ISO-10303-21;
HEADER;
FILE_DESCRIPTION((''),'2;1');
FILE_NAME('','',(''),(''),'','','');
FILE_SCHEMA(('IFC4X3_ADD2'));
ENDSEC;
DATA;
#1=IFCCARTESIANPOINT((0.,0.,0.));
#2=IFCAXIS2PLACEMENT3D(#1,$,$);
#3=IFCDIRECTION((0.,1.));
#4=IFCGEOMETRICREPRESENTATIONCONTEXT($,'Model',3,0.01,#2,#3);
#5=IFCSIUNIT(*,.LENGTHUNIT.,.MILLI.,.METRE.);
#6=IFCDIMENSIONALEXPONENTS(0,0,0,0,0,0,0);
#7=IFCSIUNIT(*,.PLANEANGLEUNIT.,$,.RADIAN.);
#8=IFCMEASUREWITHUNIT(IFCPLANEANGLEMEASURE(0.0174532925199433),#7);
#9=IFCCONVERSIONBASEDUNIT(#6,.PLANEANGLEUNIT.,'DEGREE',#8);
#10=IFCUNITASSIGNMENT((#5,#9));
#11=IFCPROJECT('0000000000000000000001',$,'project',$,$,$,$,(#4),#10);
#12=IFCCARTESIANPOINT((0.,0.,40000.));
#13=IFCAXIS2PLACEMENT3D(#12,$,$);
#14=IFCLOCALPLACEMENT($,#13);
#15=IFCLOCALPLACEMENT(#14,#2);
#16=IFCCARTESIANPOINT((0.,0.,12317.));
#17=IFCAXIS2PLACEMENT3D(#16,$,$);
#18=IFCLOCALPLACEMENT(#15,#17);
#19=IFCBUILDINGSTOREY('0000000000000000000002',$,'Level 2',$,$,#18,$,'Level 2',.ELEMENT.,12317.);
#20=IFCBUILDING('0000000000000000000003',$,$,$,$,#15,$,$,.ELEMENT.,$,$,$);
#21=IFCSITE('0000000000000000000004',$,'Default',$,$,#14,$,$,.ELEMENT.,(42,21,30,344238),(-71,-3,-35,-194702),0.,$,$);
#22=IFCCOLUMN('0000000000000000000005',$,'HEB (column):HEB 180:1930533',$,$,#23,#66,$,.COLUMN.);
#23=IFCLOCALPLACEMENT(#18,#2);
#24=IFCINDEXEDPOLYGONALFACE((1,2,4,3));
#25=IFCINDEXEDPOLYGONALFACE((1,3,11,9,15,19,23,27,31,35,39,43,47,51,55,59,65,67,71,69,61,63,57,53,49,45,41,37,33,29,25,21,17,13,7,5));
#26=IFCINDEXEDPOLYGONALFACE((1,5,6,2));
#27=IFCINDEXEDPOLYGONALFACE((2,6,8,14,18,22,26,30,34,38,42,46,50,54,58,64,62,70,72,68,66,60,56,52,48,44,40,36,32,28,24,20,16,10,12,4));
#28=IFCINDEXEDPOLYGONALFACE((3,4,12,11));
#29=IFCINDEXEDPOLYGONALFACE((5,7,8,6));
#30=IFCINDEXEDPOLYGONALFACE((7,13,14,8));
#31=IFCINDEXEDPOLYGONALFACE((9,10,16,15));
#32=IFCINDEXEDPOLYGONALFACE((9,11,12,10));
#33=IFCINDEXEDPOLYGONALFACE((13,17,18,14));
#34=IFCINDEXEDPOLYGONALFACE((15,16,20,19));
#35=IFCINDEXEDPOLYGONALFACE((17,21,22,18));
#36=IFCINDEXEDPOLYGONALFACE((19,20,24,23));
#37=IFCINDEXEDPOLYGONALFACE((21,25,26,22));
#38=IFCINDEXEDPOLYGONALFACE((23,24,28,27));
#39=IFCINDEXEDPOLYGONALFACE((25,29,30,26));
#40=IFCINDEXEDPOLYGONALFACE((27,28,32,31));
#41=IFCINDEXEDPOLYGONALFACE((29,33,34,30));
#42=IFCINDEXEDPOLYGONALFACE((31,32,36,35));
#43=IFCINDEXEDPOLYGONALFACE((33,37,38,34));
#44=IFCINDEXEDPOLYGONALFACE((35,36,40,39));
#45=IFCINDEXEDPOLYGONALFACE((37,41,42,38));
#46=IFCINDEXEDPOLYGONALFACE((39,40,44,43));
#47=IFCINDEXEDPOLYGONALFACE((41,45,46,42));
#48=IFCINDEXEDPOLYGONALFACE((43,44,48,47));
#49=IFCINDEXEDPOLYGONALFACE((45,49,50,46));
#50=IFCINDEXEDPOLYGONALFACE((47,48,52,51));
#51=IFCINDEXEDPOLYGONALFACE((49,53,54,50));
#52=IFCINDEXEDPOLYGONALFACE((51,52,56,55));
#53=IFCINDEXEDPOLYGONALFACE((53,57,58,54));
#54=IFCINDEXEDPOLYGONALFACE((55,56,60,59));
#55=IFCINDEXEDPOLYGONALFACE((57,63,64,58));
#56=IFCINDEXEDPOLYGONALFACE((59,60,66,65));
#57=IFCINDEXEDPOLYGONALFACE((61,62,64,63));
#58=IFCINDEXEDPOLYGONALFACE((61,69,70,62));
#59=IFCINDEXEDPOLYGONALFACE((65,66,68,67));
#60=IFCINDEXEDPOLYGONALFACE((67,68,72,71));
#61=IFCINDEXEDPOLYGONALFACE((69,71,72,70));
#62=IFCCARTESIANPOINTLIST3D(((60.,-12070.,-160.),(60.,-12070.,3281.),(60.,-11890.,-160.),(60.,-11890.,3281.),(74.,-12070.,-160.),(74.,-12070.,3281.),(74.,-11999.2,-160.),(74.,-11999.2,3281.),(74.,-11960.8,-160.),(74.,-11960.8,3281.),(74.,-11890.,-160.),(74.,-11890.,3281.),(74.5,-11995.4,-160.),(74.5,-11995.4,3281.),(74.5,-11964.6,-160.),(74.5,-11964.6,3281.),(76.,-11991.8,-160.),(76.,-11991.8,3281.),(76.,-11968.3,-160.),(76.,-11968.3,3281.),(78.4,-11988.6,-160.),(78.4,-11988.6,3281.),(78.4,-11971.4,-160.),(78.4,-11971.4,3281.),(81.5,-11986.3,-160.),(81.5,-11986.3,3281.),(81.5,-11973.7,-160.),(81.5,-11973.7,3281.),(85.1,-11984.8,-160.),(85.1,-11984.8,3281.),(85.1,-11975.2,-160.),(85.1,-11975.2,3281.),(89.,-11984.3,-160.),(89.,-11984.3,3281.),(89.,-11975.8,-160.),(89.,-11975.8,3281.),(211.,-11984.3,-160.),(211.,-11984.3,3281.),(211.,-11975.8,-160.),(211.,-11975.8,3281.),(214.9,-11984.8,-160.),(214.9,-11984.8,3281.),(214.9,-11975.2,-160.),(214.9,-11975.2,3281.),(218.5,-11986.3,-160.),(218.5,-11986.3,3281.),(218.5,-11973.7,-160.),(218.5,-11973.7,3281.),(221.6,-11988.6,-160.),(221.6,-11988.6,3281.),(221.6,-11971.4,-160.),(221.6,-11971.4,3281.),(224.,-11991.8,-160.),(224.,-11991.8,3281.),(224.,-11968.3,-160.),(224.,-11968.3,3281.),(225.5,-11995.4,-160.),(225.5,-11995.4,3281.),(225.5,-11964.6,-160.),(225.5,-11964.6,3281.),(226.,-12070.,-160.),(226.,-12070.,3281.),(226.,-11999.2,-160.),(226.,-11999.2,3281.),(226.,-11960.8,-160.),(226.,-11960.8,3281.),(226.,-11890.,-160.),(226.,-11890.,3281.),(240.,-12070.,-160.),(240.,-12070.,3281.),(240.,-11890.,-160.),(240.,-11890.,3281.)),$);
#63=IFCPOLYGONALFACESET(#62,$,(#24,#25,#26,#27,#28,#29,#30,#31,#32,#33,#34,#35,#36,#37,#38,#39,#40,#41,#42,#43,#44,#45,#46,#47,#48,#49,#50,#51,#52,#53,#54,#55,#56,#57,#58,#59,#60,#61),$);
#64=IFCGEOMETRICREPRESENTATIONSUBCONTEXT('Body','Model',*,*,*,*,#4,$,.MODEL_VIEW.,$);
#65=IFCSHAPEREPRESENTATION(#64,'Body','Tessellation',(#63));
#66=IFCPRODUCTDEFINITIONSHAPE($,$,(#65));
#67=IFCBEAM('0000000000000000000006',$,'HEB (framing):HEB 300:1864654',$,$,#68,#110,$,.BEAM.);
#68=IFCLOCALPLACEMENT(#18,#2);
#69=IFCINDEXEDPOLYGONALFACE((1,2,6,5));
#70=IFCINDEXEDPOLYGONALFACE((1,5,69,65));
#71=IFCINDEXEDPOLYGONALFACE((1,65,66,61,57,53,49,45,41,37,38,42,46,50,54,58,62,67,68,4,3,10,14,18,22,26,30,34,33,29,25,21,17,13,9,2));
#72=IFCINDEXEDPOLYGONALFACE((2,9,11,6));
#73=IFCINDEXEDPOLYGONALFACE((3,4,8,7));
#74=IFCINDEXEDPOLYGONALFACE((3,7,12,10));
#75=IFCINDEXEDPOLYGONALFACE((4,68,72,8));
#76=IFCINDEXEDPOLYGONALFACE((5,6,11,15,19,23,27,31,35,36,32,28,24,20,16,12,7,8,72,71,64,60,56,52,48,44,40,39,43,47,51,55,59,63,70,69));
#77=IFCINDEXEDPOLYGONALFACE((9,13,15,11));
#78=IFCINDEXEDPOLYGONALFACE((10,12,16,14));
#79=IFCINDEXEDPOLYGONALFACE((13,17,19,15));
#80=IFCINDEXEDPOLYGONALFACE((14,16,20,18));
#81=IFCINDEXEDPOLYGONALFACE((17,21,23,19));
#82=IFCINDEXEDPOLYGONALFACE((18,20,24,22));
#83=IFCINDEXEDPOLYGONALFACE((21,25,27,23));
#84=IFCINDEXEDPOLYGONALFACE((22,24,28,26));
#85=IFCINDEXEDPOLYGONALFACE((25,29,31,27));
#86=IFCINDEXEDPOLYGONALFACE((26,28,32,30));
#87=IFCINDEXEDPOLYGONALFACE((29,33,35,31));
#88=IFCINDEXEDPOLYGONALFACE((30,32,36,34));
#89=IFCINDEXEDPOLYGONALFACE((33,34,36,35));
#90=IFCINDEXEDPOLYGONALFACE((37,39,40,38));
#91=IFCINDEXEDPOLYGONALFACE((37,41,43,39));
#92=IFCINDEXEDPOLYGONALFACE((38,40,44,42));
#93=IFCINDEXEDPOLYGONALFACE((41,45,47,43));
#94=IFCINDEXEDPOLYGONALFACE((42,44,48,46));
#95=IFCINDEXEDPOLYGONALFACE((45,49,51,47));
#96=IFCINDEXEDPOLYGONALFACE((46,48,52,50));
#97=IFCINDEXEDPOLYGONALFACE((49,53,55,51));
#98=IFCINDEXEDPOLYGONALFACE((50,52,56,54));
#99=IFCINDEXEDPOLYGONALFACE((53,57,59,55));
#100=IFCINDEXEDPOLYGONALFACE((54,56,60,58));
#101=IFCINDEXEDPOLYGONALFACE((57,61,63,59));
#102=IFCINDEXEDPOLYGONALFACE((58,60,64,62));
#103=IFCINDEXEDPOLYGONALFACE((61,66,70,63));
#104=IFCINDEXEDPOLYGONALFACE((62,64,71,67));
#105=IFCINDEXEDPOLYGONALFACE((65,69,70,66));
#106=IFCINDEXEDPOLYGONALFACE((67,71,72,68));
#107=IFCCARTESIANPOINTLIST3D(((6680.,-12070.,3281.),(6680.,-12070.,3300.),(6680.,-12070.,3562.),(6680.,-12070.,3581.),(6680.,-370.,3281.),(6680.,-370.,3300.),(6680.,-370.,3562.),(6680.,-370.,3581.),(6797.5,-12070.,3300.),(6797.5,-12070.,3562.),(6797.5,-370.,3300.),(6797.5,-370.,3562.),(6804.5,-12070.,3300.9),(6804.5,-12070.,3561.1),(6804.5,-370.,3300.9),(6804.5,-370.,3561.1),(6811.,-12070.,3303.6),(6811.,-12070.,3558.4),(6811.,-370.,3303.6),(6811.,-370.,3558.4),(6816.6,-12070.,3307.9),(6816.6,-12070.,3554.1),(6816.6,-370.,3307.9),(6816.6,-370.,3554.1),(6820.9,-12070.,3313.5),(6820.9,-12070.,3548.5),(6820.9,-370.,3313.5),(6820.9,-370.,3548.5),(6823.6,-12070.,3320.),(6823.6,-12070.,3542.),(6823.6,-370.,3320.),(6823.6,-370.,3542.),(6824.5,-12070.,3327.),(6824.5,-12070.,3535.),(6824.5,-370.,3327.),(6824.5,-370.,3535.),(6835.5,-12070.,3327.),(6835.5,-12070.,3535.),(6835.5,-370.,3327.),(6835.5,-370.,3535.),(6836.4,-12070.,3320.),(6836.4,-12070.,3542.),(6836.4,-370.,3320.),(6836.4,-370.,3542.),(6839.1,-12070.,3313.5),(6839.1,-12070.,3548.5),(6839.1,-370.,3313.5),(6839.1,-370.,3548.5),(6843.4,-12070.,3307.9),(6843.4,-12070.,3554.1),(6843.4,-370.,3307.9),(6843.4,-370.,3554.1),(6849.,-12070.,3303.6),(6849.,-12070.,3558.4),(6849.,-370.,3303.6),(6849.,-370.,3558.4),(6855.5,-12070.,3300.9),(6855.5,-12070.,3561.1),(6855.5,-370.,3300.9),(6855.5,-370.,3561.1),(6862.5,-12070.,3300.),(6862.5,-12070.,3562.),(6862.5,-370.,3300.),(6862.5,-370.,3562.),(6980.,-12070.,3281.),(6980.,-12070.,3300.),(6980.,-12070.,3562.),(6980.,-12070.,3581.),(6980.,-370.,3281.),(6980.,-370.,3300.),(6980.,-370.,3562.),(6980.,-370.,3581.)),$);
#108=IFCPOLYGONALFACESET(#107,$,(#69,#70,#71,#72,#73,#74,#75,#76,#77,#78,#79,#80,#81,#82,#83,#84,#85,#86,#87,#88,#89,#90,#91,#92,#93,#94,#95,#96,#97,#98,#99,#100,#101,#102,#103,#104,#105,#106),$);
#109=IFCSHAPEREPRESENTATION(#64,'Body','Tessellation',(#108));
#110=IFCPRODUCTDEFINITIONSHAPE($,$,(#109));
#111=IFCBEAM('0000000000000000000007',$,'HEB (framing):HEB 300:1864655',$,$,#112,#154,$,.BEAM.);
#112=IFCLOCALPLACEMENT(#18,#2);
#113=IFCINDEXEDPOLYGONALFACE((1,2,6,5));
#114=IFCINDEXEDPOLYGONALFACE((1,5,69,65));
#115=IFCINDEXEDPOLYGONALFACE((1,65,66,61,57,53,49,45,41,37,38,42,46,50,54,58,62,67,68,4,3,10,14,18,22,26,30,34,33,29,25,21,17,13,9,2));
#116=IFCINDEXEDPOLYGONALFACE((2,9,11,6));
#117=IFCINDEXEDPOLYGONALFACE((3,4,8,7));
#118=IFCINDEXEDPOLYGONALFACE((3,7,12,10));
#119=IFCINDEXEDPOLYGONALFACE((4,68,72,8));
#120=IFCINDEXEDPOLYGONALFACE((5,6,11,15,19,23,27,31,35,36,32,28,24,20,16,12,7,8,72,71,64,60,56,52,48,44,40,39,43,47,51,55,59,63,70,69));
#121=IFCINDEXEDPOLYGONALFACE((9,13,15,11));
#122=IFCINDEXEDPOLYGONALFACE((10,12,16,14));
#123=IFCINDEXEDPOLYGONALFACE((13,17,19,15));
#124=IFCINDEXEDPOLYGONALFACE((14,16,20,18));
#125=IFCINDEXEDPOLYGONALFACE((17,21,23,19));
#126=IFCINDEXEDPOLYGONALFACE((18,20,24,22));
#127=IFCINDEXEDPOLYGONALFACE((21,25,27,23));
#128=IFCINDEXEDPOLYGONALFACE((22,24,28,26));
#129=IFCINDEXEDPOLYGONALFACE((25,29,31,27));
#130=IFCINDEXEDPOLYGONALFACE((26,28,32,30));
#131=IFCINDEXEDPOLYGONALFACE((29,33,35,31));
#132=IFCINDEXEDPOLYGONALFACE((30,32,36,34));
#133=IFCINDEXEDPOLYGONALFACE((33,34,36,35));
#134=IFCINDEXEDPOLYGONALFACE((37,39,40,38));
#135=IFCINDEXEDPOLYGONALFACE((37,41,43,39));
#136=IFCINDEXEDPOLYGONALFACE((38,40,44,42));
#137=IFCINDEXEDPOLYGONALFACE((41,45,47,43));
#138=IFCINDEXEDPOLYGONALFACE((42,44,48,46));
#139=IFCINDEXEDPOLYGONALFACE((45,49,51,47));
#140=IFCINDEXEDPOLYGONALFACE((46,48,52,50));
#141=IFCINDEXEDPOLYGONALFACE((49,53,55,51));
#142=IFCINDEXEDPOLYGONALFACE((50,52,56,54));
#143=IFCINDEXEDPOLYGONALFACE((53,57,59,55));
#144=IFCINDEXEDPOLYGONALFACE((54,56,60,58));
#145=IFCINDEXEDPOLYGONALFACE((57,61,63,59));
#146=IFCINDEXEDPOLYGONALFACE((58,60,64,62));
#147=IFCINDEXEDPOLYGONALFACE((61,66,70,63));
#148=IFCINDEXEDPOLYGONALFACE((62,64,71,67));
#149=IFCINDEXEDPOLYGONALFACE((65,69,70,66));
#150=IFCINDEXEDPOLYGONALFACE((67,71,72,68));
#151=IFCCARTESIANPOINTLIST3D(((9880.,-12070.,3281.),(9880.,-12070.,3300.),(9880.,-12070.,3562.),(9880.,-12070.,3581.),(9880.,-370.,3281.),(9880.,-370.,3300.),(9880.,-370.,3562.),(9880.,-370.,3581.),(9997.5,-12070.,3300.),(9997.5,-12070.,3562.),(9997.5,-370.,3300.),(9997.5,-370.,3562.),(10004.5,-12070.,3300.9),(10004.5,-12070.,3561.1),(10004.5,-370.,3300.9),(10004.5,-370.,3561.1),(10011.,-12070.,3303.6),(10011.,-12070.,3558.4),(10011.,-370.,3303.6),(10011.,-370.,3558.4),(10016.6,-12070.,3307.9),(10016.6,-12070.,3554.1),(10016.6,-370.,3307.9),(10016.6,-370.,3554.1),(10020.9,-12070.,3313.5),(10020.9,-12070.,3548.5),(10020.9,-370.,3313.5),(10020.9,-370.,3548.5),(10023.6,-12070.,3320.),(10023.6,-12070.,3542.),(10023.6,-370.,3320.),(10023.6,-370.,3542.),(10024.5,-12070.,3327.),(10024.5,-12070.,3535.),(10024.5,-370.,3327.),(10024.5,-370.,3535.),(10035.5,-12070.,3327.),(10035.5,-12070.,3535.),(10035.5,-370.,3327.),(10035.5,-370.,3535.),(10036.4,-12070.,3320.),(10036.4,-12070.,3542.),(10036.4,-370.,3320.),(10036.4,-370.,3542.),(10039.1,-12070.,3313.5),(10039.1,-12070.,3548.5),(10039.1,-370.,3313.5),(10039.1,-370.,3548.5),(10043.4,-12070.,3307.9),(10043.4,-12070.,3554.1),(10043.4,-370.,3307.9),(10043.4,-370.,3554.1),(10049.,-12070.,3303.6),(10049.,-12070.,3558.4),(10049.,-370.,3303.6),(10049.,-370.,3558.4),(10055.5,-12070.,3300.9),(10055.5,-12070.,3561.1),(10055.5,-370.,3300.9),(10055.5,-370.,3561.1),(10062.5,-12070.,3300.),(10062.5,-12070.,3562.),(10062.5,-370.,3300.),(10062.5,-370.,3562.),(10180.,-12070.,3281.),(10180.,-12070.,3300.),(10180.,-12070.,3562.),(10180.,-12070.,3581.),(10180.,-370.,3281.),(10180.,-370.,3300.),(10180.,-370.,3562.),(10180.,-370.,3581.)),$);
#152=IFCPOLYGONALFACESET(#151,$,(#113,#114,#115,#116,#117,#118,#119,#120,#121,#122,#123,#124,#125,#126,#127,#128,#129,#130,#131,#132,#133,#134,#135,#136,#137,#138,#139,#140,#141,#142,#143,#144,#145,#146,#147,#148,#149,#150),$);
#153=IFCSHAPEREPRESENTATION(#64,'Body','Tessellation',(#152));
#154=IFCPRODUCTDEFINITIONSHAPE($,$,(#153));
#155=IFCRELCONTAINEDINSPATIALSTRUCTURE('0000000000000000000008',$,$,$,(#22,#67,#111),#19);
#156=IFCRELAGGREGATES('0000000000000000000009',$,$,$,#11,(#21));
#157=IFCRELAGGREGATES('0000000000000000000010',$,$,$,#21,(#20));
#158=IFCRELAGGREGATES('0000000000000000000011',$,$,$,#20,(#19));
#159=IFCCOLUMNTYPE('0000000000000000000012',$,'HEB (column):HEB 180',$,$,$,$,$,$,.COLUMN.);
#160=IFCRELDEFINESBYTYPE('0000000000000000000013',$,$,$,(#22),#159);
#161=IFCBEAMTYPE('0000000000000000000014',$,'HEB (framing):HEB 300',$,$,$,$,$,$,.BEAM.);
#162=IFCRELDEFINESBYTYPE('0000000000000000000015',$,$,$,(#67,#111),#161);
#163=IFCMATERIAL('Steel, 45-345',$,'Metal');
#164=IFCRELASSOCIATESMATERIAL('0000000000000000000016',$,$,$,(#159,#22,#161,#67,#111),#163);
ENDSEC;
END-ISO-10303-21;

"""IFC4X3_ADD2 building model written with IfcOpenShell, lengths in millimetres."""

from ifc_helpers import new_model, entity, si_unit, converted_unit, direction, frame, frame_2d, origin, origin_2d_with_axis, place, context, subcontext, project, spatial, polyline, circle_curve, parameter, trimmed, segment, composite_curve, i_section, outline, extrude, source, transform, mapped, material, material_profile, profile_set, profile_usage, type_object, type_shapes, element, save


model = new_model("IFC4X3_ADD2")

# Units and contexts
model_context = context("Model", 3, precision=0.01, world=origin(), true_north=direction((0.0, 1.0)))
body_context = subcontext(model_context, "Body", "Model", "MODEL_VIEW")
ifc_project = project(units=[si_unit("LENGTHUNIT", "METRE", prefix="MILLI"), converted_unit("PLANEANGLEUNIT", "DEGREE", entity("IfcPlaneAngleMeasure", 0.0174532925199433), si_unit("PLANEANGLEUNIT", "RADIAN"), dimensions=[0, 0, 0, 0, 0, 0, 0])], contexts=[model_context])

# Site, building, storey
site_placement = place(None, frame((0.0, 0.0, 40000.0)))
site = spatial("IfcSite", under=ifc_project, at=site_placement, Name="Default", CompositionType="ELEMENT", RefLatitude=(42, 21, 30, 344238), RefLongitude=(-71, -3, -35, -194702), RefElevation=0.0)
building_placement = place(site_placement, origin())
building = spatial("IfcBuilding", under=site, at=building_placement, CompositionType="ELEMENT")
storey_placement = place(building_placement, frame((0.0, 0.0, 12317.0)))
storey = spatial("IfcBuildingStorey", under=building, at=storey_placement, Name="Level 2", LongName="Level 2", CompositionType="ELEMENT", Elevation=12317.0)

# Column
ifc_material_1 = material(Name="Steel, 45-345", Category="Metal")
ifc_material_profile_1 = material_profile(ifc_material_1, i_section(OverallWidth=180.0, OverallDepth=180.0, WebThickness=8.5, FlangeThickness=14.0, FilletRadius=15.0, at=origin_2d_with_axis()), Name="HEB 180")
ifc_profile_set_1 = profile_set([ifc_material_profile_1], Name="HEB 180")
ifc_profile_usage_1 = profile_usage(ifc_profile_set_1)
column_type = type_object("IfcColumnType", Name="HEB (column):HEB 180", PredefinedType="COLUMN", material=ifc_profile_set_1)
shared_shape_1 = source(origin(), body_context, "Body", "SweptSolid", [
    extrude(i_section(OverallWidth=180.0, OverallDepth=180.0, WebThickness=8.5, FlangeThickness=14.0, FilletRadius=15.0, at=origin_2d_with_axis()), frame((0.0, 0.0, 12157.0), z_axis=(0.0, 0.0, 1.0), x_axis=(-1.0, 0.0, 0.0)), (0.0, 0.0, 1.0), 3441.0),
])
type_shapes(column_type, [shared_shape_1])
column_1_placement = place(storey_placement, frame((150.0, -11980.0, -12317.0), z_axis=(0.0, 0.0, 1.0), x_axis=(0.0, 1.0, 0.0)))
element("IfcColumn", 1, at=column_1_placement, inside=storey, type_object=column_type, material=ifc_profile_usage_1, Name="HEB (column):HEB 180:1930533", PredefinedType="COLUMN", context=body_context, shape_type="MappedRepresentation", body=[
    mapped(shared_shape_1, transform((0.0, 0.0, 0.0), scale=1.0)),
])

# Beams
ifc_material_profile_2 = material_profile(ifc_material_1, outline(composite_curve([segment(polyline([(-150.0, -131.0), (-150.0, -150.0)]), True, "CONTINUOUS"), segment(polyline([(-150.0, -150.0), (150.0, -150.0)]), True, "CONTINUOUS"), segment(polyline([(150.0, -150.0), (150.0, -131.0)]), True, "CONTINUOUS"), segment(polyline([(150.0, -131.0), (32.5, -131.0)]), True, "CONTINUOUS"), segment(trimmed(circle_curve(frame_2d((32.5, -104.0), x_axis=(1.0, 0.0)), 27.0), [parameter(180.0)], [parameter(270.0)], True, "PARAMETER"), False, "CONTINUOUS"), segment(polyline([(5.5, -104.0), (5.5, 104.0)]), True, "CONTINUOUS"), segment(trimmed(circle_curve(frame_2d((32.5, 104.0), x_axis=(1.0, 0.0)), 27.0), [parameter(90.0)], [parameter(180.0)], True, "PARAMETER"), False, "CONTINUOUS"), segment(polyline([(32.5, 131.0), (150.0, 131.0)]), True, "CONTINUOUS"), segment(polyline([(150.0, 131.0), (150.0, 150.0)]), True, "CONTINUOUS"), segment(polyline([(150.0, 150.0), (-150.0, 150.0)]), True, "CONTINUOUS"), segment(polyline([(-150.0, 150.0), (-150.0, 131.0)]), True, "CONTINUOUS"), segment(polyline([(-150.0, 131.0), (-32.5, 131.0)]), True, "CONTINUOUS"), segment(trimmed(circle_curve(frame_2d((-32.5, 104.0), x_axis=(1.0, 0.0)), 27.0), [parameter(360.0)], [parameter(90.0)], True, "PARAMETER"), False, "CONTINUOUS"), segment(polyline([(-5.5, 104.0), (-5.5, -104.0)]), True, "CONTINUOUS"), segment(trimmed(circle_curve(frame_2d((-32.5, -104.0), x_axis=(1.0, 0.0)), 27.0), [parameter(270.0)], [parameter(0.0)], True, "PARAMETER"), False, "CONTINUOUS"), segment(polyline([(-32.5, -131.0), (-150.0, -131.0)]), True, "CONTINUOUS")], self_intersect=False)), Name="HEB 300")
ifc_profile_set_2 = profile_set([ifc_material_profile_2], Name="HEB 300")
ifc_profile_usage_2 = profile_usage(ifc_profile_set_2, cardinal=8)
beam_type_1 = type_object("IfcBeamType", Name="HEB (framing):HEB 300", PredefinedType="BEAM", material=ifc_profile_set_2)
shared_shape_2 = source(origin(), body_context, "Body", "SweptSolid", [
    extrude(outline(composite_curve([segment(polyline([(-150.0, -131.0), (-150.0, -150.0)]), True, "CONTINUOUS"), segment(polyline([(-150.0, -150.0), (150.0, -150.0)]), True, "CONTINUOUS"), segment(polyline([(150.0, -150.0), (150.0, -131.0)]), True, "CONTINUOUS"), segment(polyline([(150.0, -131.0), (32.5, -131.0)]), True, "CONTINUOUS"), segment(trimmed(circle_curve(frame_2d((32.5, -104.0), x_axis=(1.0, 0.0)), 27.0), [parameter(180.0)], [parameter(270.0)], True, "PARAMETER"), False, "CONTINUOUS"), segment(polyline([(5.5, -104.0), (5.5, 104.0)]), True, "CONTINUOUS"), segment(trimmed(circle_curve(frame_2d((32.5, 104.0), x_axis=(1.0, 0.0)), 27.0), [parameter(90.0)], [parameter(180.0)], True, "PARAMETER"), False, "CONTINUOUS"), segment(polyline([(32.5, 131.0), (150.0, 131.0)]), True, "CONTINUOUS"), segment(polyline([(150.0, 131.0), (150.0, 150.0)]), True, "CONTINUOUS"), segment(polyline([(150.0, 150.0), (-150.0, 150.0)]), True, "CONTINUOUS"), segment(polyline([(-150.0, 150.0), (-150.0, 131.0)]), True, "CONTINUOUS"), segment(polyline([(-150.0, 131.0), (-32.5, 131.0)]), True, "CONTINUOUS"), segment(trimmed(circle_curve(frame_2d((-32.5, 104.0), x_axis=(1.0, 0.0)), 27.0), [parameter(360.0)], [parameter(90.0)], True, "PARAMETER"), False, "CONTINUOUS"), segment(polyline([(-5.5, 104.0), (-5.5, -104.0)]), True, "CONTINUOUS"), segment(trimmed(circle_curve(frame_2d((-32.5, -104.0), x_axis=(1.0, 0.0)), 27.0), [parameter(270.0)], [parameter(0.0)], True, "PARAMETER"), False, "CONTINUOUS"), segment(polyline([(-32.5, -131.0), (-150.0, -131.0)]), True, "CONTINUOUS")], self_intersect=False)), frame((-5850.0, 0.0, 0.0), z_axis=(-1.0, 0.0, 0.0), x_axis=(0.0, -1.0, 0.0)), (0.0, 0.0, -1.0), 11700.0),
])
type_shapes(beam_type_1, [shared_shape_2])
for number, where, z_axis, x_axis, name in (
    (2, (6830.0, -6220.0, 3431.0), (0.0, 0.0, 1.0), (0.0, -1.0, 0.0), "HEB (framing):HEB 300:1864654"),
    (3, (10030.0, -6220.0, 3431.0), (0.0, 0.0, 1.0), (0.0, -1.0, 0.0), "HEB (framing):HEB 300:1864655"),
):
    element("IfcBeam", number, at=place(storey_placement, frame(where, z_axis=z_axis, x_axis=x_axis)), inside=storey, type_object=beam_type_1, material=ifc_profile_usage_2, Name=name, PredefinedType="BEAM", context=body_context, shape_type="MappedRepresentation", body=[
        mapped(shared_shape_2, transform((0.0, 0.0, 0.0), scale=1.0)),
    ])

save(model, "model.ifc")
